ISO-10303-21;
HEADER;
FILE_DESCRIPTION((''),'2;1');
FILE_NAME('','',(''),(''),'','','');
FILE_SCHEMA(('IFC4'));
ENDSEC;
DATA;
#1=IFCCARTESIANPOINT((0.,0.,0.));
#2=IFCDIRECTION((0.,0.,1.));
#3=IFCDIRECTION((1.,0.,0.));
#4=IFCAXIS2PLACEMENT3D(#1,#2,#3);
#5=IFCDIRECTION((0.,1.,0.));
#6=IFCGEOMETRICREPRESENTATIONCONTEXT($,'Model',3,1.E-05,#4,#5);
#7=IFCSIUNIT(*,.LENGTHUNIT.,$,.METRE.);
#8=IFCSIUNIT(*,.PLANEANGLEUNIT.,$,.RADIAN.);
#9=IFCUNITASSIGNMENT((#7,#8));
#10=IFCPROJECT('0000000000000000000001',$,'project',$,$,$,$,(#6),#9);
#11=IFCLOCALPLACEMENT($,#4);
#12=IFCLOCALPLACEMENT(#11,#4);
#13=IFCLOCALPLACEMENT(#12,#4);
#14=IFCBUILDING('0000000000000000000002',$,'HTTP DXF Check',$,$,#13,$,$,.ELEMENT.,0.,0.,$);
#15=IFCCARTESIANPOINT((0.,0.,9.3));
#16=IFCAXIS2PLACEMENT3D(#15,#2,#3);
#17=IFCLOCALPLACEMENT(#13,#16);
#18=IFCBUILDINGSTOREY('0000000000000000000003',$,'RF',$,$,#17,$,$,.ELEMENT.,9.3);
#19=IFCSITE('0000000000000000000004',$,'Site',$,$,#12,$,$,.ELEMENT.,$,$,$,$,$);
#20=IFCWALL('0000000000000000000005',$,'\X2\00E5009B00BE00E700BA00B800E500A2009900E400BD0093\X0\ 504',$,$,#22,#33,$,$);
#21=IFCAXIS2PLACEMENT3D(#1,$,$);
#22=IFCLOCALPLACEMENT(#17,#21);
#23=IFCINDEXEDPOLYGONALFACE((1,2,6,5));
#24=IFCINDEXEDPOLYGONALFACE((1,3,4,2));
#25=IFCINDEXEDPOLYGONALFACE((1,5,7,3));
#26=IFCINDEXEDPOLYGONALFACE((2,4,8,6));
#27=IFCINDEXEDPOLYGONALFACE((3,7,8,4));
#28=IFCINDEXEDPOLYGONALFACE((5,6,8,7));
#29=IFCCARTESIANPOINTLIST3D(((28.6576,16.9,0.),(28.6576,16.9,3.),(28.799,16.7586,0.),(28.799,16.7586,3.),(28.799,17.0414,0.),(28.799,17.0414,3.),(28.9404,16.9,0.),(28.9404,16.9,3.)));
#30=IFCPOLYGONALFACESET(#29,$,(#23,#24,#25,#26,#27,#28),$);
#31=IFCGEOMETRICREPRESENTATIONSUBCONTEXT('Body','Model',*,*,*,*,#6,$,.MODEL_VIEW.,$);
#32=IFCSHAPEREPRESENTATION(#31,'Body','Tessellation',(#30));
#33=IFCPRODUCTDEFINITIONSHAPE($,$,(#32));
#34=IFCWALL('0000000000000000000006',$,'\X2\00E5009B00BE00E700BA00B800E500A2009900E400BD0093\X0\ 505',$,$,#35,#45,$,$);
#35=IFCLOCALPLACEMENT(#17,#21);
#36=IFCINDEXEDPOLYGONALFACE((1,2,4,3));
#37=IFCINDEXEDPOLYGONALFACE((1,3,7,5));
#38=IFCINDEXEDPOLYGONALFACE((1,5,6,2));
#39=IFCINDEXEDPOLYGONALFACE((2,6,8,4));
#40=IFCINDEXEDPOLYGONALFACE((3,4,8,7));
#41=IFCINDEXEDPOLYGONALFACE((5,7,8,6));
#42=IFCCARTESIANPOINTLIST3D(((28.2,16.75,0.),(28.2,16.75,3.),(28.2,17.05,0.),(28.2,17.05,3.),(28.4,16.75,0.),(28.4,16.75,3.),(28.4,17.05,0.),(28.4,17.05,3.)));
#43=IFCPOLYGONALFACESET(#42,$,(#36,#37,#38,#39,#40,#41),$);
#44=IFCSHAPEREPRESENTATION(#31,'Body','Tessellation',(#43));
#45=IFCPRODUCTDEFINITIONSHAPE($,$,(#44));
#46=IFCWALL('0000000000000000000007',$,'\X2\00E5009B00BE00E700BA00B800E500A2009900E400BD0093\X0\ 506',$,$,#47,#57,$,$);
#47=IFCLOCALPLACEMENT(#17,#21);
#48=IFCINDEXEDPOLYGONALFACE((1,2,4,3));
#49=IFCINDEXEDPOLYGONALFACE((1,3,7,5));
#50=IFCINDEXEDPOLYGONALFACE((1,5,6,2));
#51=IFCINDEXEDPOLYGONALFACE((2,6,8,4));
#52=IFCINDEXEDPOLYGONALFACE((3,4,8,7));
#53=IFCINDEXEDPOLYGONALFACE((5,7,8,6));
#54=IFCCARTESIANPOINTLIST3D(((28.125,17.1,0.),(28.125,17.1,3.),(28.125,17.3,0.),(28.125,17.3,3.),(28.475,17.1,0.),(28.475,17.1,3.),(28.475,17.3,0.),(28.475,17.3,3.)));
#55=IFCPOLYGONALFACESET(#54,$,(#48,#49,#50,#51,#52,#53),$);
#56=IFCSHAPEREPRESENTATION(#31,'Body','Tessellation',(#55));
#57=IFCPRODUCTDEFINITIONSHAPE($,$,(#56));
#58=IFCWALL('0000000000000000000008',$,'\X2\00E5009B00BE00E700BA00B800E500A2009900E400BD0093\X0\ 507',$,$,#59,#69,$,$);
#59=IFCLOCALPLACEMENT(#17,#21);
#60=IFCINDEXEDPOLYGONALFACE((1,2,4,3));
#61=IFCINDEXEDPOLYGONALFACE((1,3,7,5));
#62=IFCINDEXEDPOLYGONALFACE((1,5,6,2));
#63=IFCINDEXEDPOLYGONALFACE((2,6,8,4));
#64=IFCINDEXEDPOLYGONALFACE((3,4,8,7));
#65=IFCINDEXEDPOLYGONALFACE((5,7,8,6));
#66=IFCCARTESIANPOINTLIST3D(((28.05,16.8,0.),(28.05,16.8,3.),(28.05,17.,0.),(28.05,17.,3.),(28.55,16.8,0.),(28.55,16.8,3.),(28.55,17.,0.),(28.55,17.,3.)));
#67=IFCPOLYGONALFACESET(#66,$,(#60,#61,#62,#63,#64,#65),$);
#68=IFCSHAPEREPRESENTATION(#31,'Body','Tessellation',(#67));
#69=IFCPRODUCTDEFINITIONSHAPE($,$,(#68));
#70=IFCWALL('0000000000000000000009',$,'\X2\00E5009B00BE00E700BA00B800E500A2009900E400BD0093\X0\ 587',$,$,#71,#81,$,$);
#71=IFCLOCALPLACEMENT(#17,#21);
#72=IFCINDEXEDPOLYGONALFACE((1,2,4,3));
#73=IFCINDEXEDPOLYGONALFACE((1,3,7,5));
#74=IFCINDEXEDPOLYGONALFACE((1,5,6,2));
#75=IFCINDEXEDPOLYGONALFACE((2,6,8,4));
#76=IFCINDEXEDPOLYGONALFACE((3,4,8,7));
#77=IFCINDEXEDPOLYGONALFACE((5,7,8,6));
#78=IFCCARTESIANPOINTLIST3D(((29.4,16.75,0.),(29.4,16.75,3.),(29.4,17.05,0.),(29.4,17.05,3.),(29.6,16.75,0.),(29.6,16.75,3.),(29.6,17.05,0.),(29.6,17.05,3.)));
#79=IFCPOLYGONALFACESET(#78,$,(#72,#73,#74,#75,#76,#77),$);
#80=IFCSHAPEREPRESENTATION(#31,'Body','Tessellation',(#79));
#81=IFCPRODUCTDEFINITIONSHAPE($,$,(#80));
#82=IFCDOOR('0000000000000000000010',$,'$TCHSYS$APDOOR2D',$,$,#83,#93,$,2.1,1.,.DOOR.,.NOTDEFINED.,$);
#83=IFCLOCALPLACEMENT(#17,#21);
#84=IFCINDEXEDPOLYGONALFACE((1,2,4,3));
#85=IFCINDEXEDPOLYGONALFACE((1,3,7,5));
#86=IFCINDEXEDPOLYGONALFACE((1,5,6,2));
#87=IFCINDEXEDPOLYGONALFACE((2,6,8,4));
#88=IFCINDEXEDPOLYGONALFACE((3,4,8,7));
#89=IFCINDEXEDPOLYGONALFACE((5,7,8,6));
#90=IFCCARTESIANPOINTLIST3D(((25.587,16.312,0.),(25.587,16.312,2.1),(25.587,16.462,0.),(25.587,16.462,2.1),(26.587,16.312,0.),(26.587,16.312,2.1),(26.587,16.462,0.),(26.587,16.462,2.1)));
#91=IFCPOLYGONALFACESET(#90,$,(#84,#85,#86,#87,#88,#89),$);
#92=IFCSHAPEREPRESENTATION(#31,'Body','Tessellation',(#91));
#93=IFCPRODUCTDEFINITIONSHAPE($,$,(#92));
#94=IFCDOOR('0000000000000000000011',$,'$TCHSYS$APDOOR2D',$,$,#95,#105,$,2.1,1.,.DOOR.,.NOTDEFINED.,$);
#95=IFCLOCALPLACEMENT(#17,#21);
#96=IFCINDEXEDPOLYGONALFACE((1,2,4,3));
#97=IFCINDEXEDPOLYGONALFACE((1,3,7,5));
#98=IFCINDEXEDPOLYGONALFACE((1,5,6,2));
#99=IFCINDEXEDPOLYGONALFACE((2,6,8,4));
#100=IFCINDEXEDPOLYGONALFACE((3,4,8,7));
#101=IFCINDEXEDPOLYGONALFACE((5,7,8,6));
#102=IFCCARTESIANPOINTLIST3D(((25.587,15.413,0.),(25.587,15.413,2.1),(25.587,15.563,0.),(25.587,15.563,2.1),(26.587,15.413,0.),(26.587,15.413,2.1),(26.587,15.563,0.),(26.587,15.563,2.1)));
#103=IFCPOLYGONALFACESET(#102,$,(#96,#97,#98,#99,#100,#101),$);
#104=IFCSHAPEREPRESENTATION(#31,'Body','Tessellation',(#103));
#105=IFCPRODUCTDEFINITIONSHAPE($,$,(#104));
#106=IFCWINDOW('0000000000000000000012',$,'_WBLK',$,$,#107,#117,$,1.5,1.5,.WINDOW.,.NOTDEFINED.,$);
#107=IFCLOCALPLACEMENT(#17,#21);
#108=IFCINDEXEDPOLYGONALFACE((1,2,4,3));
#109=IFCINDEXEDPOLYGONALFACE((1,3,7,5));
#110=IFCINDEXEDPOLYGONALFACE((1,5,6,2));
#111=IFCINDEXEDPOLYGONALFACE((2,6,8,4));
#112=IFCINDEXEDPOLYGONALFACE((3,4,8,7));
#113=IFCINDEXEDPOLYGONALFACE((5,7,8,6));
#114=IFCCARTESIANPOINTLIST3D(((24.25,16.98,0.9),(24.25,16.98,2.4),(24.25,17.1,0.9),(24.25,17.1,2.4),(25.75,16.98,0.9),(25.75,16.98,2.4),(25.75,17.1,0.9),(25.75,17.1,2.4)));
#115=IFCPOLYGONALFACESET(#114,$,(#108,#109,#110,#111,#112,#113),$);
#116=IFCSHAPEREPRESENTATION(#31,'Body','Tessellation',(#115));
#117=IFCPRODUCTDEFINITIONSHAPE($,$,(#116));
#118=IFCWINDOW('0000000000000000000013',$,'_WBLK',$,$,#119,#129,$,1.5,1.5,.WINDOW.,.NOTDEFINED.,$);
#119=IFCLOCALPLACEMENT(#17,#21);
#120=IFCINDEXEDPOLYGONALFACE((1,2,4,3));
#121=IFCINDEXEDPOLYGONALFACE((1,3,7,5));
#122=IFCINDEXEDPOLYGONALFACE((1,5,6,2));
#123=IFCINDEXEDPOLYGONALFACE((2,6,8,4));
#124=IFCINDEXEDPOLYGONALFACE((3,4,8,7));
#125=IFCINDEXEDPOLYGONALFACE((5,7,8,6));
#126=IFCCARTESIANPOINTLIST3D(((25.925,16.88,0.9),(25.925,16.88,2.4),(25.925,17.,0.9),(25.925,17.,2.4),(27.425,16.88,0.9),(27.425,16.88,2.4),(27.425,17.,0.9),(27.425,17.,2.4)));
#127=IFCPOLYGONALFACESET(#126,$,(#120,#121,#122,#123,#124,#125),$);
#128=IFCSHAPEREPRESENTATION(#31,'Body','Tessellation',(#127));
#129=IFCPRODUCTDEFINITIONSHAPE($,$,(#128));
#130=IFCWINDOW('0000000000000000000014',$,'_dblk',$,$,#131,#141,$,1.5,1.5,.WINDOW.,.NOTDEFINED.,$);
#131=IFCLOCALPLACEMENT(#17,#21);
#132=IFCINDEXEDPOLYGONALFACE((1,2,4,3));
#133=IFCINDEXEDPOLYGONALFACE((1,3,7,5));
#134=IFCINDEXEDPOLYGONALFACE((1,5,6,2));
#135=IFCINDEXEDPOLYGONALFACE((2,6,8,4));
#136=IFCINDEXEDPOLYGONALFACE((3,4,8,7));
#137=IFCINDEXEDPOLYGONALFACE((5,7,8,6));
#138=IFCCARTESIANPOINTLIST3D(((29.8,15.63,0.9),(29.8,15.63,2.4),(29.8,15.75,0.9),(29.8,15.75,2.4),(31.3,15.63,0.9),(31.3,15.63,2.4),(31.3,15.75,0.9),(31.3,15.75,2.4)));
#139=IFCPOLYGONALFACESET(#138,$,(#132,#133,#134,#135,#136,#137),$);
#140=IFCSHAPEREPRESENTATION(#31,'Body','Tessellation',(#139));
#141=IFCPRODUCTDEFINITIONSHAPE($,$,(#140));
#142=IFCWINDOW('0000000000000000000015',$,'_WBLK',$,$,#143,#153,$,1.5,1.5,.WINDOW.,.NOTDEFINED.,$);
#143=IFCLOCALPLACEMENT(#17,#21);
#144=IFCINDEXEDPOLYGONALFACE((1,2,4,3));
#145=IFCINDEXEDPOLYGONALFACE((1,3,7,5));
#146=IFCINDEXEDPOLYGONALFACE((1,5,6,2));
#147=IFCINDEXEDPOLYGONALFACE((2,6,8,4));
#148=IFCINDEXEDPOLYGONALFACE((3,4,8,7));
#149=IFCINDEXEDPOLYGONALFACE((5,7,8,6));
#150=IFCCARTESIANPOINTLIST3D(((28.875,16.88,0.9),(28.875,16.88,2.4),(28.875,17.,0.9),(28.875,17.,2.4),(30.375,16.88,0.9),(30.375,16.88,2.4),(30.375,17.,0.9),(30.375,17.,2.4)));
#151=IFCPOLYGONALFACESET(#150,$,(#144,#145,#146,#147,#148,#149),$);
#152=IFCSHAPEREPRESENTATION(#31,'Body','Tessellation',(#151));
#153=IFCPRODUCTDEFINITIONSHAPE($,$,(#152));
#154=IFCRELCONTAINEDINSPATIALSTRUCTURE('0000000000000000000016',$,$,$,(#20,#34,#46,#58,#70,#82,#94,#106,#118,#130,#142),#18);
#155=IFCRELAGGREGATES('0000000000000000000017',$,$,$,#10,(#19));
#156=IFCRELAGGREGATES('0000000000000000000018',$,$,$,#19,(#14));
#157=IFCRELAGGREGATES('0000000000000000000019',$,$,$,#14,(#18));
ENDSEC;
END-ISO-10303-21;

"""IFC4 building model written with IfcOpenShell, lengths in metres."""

from ifc_helpers import new_model, si_unit, direction, frame, frame_2d, origin_with_axes, place, context, subcontext, project, spatial, rectangle, extrude, element, save


model = new_model("IFC4")

# Units and contexts
model_context = context("Model", 3, precision=1e-05, world=origin_with_axes(), true_north=direction((0.0, 1.0, 0.0)))
body_context = subcontext(model_context, "Body", "Model", "MODEL_VIEW")
ifc_project = project(units=[si_unit("LENGTHUNIT", "METRE"), si_unit("PLANEANGLEUNIT", "RADIAN")], contexts=[model_context])

# Site, building, storey
placement = place(None, origin_with_axes())
site_placement = place(placement, origin_with_axes())
site = spatial("IfcSite", under=ifc_project, at=site_placement, Name="Site", CompositionType="ELEMENT")
building_placement = place(site_placement, origin_with_axes())
building = spatial("IfcBuilding", under=site, at=building_placement, Name="HTTP DXF Check", CompositionType="ELEMENT", ElevationOfRefHeight=0.0, ElevationOfTerrain=0.0)
storey_placement = place(building_placement, frame((0.0, 0.0, 9.3), z_axis=(0.0, 0.0, 1.0), x_axis=(1.0, 0.0, 0.0)))
storey = spatial("IfcBuildingStorey", under=building, at=storey_placement, Name="RF", CompositionType="ELEMENT", Elevation=9.3)

# Walls
for number, where, z_axis, x_axis, name in (
    (1, (28.799, 16.9, 0.0), (0.0, 0.0, 1.0), (0.707107, -0.707107, 0.0), "å\u009b¾çº¸å¢\u0099ä½\u0093 504"),
):
    element("IfcWall", number, at=place(storey_placement, frame(where, z_axis=z_axis, x_axis=x_axis)), inside=storey, Name=name, context=body_context, shape_type="SweptSolid", body=[
        extrude(rectangle(XDim=0.2, YDim=0.2, at=frame_2d((0.0, 0.0), x_axis=(1.0, 0.0, 0.0))), frame((0.0, 0.0, 0.0), z_axis=(0.0, 0.0, 1.0)), (0.0, 0.0, 1.0), 3.0),
    ])
wall_1_placement = place(storey_placement, frame((28.3, 16.9, 0.0), z_axis=(0.0, 0.0, 1.0), x_axis=(0.0, 1.0, 0.0)))
element("IfcWall", 2, at=wall_1_placement, inside=storey, Name="å\u009b¾çº¸å¢\u0099ä½\u0093 505", context=body_context, shape_type="SweptSolid", body=[
    extrude(rectangle(XDim=0.3, YDim=0.2, at=frame_2d((0.0, 0.0), x_axis=(1.0, 0.0, 0.0))), frame((0.0, 0.0, 0.0), z_axis=(0.0, 0.0, 1.0)), (0.0, 0.0, 1.0), 3.0),
])
wall_2_placement = place(storey_placement, frame((28.3, 17.2, 0.0), z_axis=(0.0, 0.0, 1.0), x_axis=(1.0, 0.0, 0.0)))
element("IfcWall", 3, at=wall_2_placement, inside=storey, Name="å\u009b¾çº¸å¢\u0099ä½\u0093 506", context=body_context, shape_type="SweptSolid", body=[
    extrude(rectangle(XDim=0.35, YDim=0.2, at=frame_2d((0.0, 0.0), x_axis=(1.0, 0.0, 0.0))), frame((0.0, 0.0, 0.0), z_axis=(0.0, 0.0, 1.0)), (0.0, 0.0, 1.0), 3.0),
])
wall_3_placement = place(storey_placement, frame((28.3, 16.9, 0.0), z_axis=(0.0, 0.0, 1.0), x_axis=(1.0, 0.0, 0.0)))
element("IfcWall", 4, at=wall_3_placement, inside=storey, Name="å\u009b¾çº¸å¢\u0099ä½\u0093 507", context=body_context, shape_type="SweptSolid", body=[
    extrude(rectangle(XDim=0.5, YDim=0.2, at=frame_2d((0.0, 0.0), x_axis=(1.0, 0.0, 0.0))), frame((0.0, 0.0, 0.0), z_axis=(0.0, 0.0, 1.0)), (0.0, 0.0, 1.0), 3.0),
])
wall_4_placement = place(storey_placement, frame((29.5, 16.9, 0.0), z_axis=(0.0, 0.0, 1.0), x_axis=(0.0, 1.0, 0.0)))
element("IfcWall", 5, at=wall_4_placement, inside=storey, Name="å\u009b¾çº¸å¢\u0099ä½\u0093 587", context=body_context, shape_type="SweptSolid", body=[
    extrude(rectangle(XDim=0.3, YDim=0.2, at=frame_2d((0.0, 0.0), x_axis=(1.0, 0.0, 0.0))), frame((0.0, 0.0, 0.0), z_axis=(0.0, 0.0, 1.0)), (0.0, 0.0, 1.0), 3.0),
])

# Doors
for number, where, z_axis, x_axis, name in (
    (6, (26.087, 16.387, 0.0), (0.0, 0.0, 1.0), (1.0, 0.0, 0.0), "$TCHSYS$APDOOR2D"),
    (7, (26.087, 15.488, 0.0), (0.0, 0.0, 1.0), (1.0, 0.0, 0.0), "$TCHSYS$APDOOR2D"),
):
    element("IfcDoor", number, at=place(storey_placement, frame(where, z_axis=z_axis, x_axis=x_axis)), inside=storey, Name=name, OperationType="NOTDEFINED", OverallHeight=2.1, OverallWidth=1.0, PredefinedType="DOOR", context=body_context, shape_type="SweptSolid", body=[
        extrude(rectangle(XDim=1.0, YDim=0.15, at=frame_2d((0.0, 0.0), x_axis=(1.0, 0.0, 0.0))), frame((0.0, 0.0, 0.0), z_axis=(0.0, 0.0, 1.0)), (0.0, 0.0, 1.0), 2.1),
    ])

# Windows
for number, where, z_axis, x_axis, name in (
    (8, (25.0, 17.04, 0.9), (0.0, 0.0, 1.0), (1.0, 0.0, 0.0), "_WBLK"),
    (9, (26.675, 16.94, 0.9), (0.0, 0.0, 1.0), (1.0, 0.0, 0.0), "_WBLK"),
    (10, (30.55, 15.69, 0.9), (0.0, 0.0, 1.0), (1.0, 0.0, 0.0), "_dblk"),
    (11, (29.625, 16.94, 0.9), (0.0, 0.0, 1.0), (1.0, 0.0, 0.0), "_WBLK"),
):
    element("IfcWindow", number, at=place(storey_placement, frame(where, z_axis=z_axis, x_axis=x_axis)), inside=storey, Name=name, OverallHeight=1.5, OverallWidth=1.5, PartitioningType="NOTDEFINED", PredefinedType="WINDOW", context=body_context, shape_type="SweptSolid", body=[
        extrude(rectangle(XDim=1.5, YDim=0.12, at=frame_2d((0.0, 0.0), x_axis=(1.0, 0.0, 0.0))), frame((0.0, 0.0, 0.0), z_axis=(0.0, 0.0, 1.0)), (0.0, 0.0, 1.0), 1.5),
    ])

save(model, "model.ifc")
